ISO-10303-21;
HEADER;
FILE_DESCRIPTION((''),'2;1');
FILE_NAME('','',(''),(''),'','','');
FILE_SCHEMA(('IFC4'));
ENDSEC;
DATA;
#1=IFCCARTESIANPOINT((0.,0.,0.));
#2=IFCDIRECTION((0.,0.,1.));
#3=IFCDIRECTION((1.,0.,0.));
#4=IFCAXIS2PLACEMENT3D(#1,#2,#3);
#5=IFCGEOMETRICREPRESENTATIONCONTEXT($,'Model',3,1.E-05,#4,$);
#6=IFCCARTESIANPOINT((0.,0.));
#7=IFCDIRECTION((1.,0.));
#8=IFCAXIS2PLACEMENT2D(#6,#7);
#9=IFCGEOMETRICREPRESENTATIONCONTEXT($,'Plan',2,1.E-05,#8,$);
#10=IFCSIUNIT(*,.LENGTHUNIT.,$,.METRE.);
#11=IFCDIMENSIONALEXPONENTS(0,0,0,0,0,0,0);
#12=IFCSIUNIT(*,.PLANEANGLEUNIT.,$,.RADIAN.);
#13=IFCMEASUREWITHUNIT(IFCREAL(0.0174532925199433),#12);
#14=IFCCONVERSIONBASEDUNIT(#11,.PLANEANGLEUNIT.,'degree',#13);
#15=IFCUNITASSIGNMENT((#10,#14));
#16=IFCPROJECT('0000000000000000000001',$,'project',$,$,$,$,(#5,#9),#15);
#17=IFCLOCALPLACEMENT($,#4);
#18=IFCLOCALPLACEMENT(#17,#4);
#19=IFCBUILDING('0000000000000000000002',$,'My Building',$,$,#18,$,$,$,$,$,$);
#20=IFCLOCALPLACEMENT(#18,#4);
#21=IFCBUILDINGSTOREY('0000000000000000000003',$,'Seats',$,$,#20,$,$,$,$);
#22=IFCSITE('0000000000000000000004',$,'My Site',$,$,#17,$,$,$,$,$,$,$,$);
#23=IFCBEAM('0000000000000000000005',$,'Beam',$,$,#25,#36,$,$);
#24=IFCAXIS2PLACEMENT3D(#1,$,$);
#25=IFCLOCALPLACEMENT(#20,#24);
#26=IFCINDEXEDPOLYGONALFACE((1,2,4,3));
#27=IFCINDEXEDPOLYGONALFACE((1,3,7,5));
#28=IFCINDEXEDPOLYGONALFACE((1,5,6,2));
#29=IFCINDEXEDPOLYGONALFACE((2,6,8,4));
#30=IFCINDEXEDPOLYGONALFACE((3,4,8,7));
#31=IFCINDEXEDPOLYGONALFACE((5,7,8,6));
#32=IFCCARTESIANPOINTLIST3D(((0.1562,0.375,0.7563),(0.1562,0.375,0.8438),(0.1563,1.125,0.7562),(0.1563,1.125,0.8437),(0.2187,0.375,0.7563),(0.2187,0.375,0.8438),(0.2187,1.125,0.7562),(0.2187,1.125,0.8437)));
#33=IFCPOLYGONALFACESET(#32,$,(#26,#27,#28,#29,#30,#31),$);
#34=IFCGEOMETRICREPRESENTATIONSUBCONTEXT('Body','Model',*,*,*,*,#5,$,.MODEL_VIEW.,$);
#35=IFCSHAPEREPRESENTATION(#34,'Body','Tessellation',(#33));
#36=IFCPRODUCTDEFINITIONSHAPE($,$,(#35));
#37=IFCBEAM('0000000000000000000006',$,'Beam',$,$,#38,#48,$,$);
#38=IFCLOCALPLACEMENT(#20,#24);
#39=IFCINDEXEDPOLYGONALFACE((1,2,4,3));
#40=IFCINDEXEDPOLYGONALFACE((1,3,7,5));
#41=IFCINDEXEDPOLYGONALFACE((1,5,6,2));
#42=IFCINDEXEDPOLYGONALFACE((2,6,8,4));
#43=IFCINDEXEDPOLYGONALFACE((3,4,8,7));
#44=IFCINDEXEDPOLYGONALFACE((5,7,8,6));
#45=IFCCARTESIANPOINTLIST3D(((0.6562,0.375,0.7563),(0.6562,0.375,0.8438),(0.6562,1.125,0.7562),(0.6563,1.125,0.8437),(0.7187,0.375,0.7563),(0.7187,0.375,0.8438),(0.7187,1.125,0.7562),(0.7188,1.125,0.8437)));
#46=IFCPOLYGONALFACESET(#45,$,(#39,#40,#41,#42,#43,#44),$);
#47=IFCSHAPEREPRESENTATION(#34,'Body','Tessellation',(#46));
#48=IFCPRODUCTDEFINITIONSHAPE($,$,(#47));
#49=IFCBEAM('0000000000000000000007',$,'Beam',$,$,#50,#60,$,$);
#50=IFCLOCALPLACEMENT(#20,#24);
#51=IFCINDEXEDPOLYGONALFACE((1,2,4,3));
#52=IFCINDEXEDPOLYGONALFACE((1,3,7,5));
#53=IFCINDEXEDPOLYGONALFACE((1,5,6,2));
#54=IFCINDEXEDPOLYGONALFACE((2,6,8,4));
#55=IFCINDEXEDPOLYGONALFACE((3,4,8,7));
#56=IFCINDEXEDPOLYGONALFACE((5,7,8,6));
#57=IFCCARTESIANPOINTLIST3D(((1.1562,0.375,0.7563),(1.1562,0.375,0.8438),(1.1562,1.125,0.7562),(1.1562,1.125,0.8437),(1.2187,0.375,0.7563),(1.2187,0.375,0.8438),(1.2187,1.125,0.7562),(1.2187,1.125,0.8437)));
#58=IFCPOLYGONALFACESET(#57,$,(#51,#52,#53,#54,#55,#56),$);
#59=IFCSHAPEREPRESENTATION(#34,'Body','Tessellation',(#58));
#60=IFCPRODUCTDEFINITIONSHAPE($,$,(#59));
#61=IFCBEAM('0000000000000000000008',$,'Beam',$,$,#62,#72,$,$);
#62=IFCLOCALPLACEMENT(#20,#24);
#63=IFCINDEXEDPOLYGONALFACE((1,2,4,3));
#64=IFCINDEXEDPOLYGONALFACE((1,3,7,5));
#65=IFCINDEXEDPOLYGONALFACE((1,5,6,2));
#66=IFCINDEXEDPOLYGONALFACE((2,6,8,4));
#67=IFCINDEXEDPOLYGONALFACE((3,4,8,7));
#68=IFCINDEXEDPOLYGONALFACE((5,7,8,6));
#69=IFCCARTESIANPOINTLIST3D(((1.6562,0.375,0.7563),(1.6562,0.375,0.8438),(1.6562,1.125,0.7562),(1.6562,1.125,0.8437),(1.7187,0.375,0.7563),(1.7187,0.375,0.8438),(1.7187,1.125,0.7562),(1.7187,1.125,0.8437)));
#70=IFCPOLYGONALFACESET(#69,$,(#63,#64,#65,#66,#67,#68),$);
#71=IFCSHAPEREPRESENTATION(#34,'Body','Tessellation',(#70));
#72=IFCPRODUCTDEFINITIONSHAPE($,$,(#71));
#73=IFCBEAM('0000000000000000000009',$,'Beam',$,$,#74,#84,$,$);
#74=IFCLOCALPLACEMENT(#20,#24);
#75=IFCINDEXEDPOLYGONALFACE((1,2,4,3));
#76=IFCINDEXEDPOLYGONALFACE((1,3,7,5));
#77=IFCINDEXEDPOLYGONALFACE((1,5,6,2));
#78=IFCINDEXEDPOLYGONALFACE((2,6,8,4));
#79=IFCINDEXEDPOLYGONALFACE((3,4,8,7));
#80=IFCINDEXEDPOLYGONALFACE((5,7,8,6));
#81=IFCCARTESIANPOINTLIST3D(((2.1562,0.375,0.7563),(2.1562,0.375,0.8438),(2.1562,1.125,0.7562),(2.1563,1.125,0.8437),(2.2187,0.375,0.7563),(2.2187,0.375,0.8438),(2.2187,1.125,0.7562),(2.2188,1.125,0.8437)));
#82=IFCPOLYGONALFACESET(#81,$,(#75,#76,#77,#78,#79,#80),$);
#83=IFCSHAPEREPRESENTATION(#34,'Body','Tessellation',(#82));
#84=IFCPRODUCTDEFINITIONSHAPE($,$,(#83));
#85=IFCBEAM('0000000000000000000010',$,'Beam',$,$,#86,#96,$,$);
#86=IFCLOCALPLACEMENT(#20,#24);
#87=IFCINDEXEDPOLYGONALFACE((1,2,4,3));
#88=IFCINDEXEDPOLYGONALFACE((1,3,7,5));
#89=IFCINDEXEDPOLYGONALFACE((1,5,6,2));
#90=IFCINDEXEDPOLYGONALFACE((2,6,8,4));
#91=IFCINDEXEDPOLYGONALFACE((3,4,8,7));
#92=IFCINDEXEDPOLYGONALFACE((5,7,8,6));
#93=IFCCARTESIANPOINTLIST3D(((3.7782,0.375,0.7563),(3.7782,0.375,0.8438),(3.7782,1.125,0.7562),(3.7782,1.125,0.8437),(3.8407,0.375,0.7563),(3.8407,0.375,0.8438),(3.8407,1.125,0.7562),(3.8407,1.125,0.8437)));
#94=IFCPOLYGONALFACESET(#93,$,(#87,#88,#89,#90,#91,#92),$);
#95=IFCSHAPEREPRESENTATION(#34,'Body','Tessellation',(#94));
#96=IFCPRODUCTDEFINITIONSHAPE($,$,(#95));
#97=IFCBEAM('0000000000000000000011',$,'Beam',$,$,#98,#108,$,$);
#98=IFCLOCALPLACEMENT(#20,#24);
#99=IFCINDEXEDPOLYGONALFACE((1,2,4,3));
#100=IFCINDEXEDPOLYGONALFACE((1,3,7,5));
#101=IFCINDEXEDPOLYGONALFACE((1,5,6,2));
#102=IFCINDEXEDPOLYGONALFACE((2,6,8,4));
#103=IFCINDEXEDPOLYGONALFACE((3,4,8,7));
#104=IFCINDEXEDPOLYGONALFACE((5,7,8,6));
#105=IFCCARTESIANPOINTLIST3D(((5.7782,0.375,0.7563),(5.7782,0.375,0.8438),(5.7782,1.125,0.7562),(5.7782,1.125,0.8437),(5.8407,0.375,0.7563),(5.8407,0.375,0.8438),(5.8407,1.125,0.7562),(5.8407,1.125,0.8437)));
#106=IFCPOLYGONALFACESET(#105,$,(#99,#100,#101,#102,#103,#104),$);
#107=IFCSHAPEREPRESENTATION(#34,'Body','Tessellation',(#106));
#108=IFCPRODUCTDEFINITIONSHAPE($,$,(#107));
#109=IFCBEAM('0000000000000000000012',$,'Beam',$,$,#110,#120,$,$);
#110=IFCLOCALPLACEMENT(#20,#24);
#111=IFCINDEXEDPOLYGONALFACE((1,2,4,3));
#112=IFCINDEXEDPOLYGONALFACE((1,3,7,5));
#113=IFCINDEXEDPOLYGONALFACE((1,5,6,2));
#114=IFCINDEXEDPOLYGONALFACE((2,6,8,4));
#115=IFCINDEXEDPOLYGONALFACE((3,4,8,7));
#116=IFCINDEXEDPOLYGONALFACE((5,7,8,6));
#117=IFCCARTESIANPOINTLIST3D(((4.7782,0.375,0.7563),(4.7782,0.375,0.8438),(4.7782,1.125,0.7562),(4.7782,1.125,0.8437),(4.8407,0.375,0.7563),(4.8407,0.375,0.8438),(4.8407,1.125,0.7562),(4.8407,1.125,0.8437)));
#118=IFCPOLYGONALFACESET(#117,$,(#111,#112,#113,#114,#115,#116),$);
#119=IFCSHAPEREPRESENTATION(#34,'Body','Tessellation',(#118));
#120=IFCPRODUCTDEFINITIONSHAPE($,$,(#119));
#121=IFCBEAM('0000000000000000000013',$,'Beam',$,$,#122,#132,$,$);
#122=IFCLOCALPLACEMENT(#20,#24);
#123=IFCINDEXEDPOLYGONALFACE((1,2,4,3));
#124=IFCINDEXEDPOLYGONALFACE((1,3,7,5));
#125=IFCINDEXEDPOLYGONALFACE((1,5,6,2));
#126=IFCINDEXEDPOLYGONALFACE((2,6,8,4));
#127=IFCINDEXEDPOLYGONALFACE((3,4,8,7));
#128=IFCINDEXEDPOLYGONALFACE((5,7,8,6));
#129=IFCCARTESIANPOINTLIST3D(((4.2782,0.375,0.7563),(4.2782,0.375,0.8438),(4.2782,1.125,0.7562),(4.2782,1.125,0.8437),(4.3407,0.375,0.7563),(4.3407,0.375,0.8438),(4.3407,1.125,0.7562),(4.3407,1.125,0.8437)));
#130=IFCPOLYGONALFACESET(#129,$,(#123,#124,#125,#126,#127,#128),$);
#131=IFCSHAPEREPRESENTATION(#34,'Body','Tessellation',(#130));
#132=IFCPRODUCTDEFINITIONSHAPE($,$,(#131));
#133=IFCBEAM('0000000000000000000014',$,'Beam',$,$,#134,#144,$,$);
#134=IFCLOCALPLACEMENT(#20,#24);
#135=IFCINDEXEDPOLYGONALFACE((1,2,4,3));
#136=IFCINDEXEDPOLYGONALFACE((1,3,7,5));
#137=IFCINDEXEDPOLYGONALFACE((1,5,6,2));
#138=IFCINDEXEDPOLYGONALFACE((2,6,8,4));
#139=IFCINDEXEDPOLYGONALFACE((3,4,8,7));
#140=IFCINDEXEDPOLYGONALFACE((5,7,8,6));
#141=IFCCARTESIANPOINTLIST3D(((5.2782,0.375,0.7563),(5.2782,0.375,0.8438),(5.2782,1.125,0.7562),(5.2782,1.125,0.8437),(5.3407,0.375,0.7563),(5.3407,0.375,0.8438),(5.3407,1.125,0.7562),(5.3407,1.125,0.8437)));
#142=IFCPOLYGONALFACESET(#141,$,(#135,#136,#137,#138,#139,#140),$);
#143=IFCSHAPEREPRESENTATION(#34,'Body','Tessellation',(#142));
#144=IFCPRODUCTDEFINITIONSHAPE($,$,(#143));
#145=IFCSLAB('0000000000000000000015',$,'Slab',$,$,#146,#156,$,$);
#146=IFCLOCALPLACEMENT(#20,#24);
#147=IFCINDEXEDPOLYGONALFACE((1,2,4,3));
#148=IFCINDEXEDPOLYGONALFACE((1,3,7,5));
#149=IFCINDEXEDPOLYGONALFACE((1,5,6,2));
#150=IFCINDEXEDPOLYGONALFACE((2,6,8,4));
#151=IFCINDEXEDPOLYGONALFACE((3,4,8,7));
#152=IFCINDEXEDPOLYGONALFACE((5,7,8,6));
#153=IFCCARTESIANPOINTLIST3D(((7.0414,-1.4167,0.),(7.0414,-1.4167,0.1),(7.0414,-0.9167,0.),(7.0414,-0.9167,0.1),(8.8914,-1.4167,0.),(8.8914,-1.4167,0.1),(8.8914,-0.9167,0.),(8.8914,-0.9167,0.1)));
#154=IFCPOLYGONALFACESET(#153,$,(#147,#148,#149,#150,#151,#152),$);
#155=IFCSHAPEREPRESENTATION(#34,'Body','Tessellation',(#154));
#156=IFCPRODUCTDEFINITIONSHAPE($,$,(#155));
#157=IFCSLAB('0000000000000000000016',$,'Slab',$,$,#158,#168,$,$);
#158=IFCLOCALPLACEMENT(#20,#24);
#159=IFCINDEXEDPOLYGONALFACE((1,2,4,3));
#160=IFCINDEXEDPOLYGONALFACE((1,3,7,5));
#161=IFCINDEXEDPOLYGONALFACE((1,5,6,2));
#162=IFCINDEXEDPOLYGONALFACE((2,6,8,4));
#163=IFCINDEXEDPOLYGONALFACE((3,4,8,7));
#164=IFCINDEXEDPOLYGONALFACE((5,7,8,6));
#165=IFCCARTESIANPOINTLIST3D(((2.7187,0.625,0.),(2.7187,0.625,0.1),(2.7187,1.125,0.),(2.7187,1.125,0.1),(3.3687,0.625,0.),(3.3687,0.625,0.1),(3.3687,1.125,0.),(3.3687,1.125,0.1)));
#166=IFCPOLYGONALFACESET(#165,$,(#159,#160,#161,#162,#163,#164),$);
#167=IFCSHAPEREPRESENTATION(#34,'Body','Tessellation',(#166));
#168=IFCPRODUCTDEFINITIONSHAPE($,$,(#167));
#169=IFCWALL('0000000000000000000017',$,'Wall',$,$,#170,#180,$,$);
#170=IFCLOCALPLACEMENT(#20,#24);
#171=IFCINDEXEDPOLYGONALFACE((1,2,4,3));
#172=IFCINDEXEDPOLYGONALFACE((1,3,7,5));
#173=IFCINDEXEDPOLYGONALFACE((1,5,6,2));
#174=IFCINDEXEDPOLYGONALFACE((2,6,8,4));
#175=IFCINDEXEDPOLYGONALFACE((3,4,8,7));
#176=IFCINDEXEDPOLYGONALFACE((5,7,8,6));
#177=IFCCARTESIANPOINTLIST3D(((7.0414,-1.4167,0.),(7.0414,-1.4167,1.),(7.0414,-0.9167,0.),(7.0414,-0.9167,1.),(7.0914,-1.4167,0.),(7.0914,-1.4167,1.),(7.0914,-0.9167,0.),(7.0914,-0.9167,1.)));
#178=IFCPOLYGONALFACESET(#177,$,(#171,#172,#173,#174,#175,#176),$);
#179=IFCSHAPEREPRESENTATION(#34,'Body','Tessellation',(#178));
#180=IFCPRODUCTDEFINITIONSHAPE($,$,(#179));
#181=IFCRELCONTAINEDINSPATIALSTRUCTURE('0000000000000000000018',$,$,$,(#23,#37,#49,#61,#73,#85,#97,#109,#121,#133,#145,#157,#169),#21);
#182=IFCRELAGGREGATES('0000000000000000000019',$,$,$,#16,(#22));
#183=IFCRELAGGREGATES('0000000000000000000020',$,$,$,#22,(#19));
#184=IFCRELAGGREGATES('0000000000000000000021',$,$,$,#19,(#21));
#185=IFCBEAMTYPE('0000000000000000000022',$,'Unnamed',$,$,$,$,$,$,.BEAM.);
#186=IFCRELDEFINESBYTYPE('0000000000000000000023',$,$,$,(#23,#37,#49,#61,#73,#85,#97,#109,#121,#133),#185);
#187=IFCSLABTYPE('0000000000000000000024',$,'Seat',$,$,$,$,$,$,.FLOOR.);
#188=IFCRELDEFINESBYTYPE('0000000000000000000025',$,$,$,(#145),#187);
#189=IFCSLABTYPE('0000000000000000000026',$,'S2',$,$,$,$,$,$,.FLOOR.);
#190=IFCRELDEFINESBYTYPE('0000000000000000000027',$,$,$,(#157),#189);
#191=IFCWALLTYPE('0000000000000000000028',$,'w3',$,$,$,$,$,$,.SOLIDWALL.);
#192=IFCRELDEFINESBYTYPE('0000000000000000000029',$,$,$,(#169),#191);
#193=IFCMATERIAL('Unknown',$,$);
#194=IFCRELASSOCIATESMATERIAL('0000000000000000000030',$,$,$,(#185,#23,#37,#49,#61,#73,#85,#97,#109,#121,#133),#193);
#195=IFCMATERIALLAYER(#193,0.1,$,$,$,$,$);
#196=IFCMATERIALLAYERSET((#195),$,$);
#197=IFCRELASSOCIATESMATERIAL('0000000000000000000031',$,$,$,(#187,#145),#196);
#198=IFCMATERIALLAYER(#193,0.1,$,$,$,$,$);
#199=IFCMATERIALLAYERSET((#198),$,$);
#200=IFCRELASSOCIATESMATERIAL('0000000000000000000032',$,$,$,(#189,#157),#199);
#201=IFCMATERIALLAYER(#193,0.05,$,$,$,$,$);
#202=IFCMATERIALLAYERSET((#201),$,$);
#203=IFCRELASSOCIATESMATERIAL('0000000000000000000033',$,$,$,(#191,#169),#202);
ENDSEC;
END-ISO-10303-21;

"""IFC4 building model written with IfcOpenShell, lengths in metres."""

from ifc_helpers import new_model, entity, si_unit, converted_unit, frame, origin_with_axes, origin_2d_with_axis, place, context, subcontext, project, spatial, line, indexed_curve, outline, extrude, material, layer, layer_set, layer_usage, material_profile, profile_set, profile_usage, type_object, element, save


model = new_model("IFC4")

# Units and contexts
model_context = context("Model", 3, precision=1e-05, world=origin_with_axes())
plan_context = context("Plan", 2, precision=1e-05, world=origin_2d_with_axis())
body_context = subcontext(model_context, "Body", "Model", "MODEL_VIEW")
ifc_project = project(units=[si_unit("LENGTHUNIT", "METRE"), converted_unit("PLANEANGLEUNIT", "degree", entity("IfcReal", 0.0174532925199433), si_unit("PLANEANGLEUNIT", "RADIAN"), dimensions=[0, 0, 0, 0, 0, 0, 0])], contexts=[model_context, plan_context])

# Site, building, storey
site_placement = place(None, origin_with_axes())
site = spatial("IfcSite", under=ifc_project, at=site_placement, Name="My Site")
building_placement = place(site_placement, origin_with_axes())
building = spatial("IfcBuilding", under=site, at=building_placement, Name="My Building")
storey_placement = place(building_placement, origin_with_axes())
storey = spatial("IfcBuildingStorey", under=building, at=storey_placement, Name="Seats")

# Beams
ifc_material = material(Name="Unknown")
ifc_material_profile = material_profile(ifc_material, outline(indexed_curve([(-0.0312, 0.0437), (0.0312, 0.0437), (0.0312, -0.0437), (-0.0312, -0.0437), (-0.0312, 0.0437)])))
ifc_profile_set = profile_set([ifc_material_profile])
ifc_profile_usage_1 = profile_usage(ifc_profile_set, cardinal=5)
beam_type = type_object("IfcBeamType", Name="Unnamed", PredefinedType="BEAM", material=ifc_profile_set)
beam_1_placement = place(storey_placement, frame((0.1875, 1.125, 0.8), z_axis=(0.0, -1.0, 0.0), x_axis=(1.0, 0.0, 0.0)))
element("IfcBeam", 1, at=beam_1_placement, inside=storey, type_object=beam_type, material=ifc_profile_usage_1, Name="Beam", context=body_context, shape_type="SweptSolid", body=[
    extrude(outline(indexed_curve([(-0.0312, 0.0437), (0.0312, 0.0437), (0.0312, -0.0437), (-0.0312, -0.0437), (-0.0312, 0.0437)])), origin_with_axes(), (0.0, 0.0, 1.0), 0.75),
])
ifc_profile_usage_2 = profile_usage(ifc_profile_set, cardinal=5)
beam_2_placement = place(storey_placement, frame((0.6875, 1.125, 0.8), z_axis=(0.0, -1.0, 0.0), x_axis=(1.0, 0.0, 0.0)))
element("IfcBeam", 2, at=beam_2_placement, inside=storey, type_object=beam_type, material=ifc_profile_usage_2, Name="Beam", context=body_context, shape_type="SweptSolid", body=[
    extrude(outline(indexed_curve([(-0.0312, 0.0437), (0.0312, 0.0437), (0.0312, -0.0437), (-0.0312, -0.0437), (-0.0312, 0.0437)])), origin_with_axes(), (0.0, 0.0, 1.0), 0.75),
])
ifc_profile_usage_3 = profile_usage(ifc_profile_set, cardinal=5)
beam_3_placement = place(storey_placement, frame((1.1875, 1.125, 0.8), z_axis=(0.0, -1.0, 0.0), x_axis=(1.0, 0.0, 0.0)))
element("IfcBeam", 3, at=beam_3_placement, inside=storey, type_object=beam_type, material=ifc_profile_usage_3, Name="Beam", context=body_context, shape_type="SweptSolid", body=[
    extrude(outline(indexed_curve([(-0.0312, 0.0437), (0.0312, 0.0437), (0.0312, -0.0437), (-0.0312, -0.0437), (-0.0312, 0.0437)])), origin_with_axes(), (0.0, 0.0, 1.0), 0.75),
])
ifc_profile_usage_4 = profile_usage(ifc_profile_set, cardinal=5)
beam_4_placement = place(storey_placement, frame((1.6875, 1.125, 0.8), z_axis=(0.0, -1.0, 0.0), x_axis=(1.0, 0.0, 0.0)))
element("IfcBeam", 4, at=beam_4_placement, inside=storey, type_object=beam_type, material=ifc_profile_usage_4, Name="Beam", context=body_context, shape_type="SweptSolid", body=[
    extrude(outline(indexed_curve([(-0.0312, 0.0437), (0.0312, 0.0437), (0.0312, -0.0437), (-0.0312, -0.0437), (-0.0312, 0.0437)])), origin_with_axes(), (0.0, 0.0, 1.0), 0.75),
])
ifc_profile_usage_5 = profile_usage(ifc_profile_set, cardinal=5)
beam_5_placement = place(storey_placement, frame((2.1875, 1.125, 0.8), z_axis=(0.0, -1.0, 0.0), x_axis=(1.0, 0.0, 0.0)))
element("IfcBeam", 5, at=beam_5_placement, inside=storey, type_object=beam_type, material=ifc_profile_usage_5, Name="Beam", context=body_context, shape_type="SweptSolid", body=[
    extrude(outline(indexed_curve([(-0.0312, 0.0437), (0.0312, 0.0437), (0.0312, -0.0437), (-0.0312, -0.0437), (-0.0312, 0.0437)])), origin_with_axes(), (0.0, 0.0, 1.0), 0.75),
])
ifc_profile_usage_6 = profile_usage(ifc_profile_set, cardinal=5)
beam_6_placement = place(storey_placement, frame((3.8094, 1.125, 0.8), z_axis=(0.0, -1.0, 0.0), x_axis=(1.0, 0.0, 0.0)))
element("IfcBeam", 6, at=beam_6_placement, inside=storey, type_object=beam_type, material=ifc_profile_usage_6, Name="Beam", context=body_context, shape_type="SweptSolid", body=[
    extrude(outline(indexed_curve([(-0.0312, 0.0437), (0.0312, 0.0437), (0.0312, -0.0437), (-0.0312, -0.0437), (-0.0312, 0.0437)])), origin_with_axes(), (0.0, 0.0, 1.0), 0.75),
])
ifc_profile_usage_7 = profile_usage(ifc_profile_set, cardinal=5)
beam_7_placement = place(storey_placement, frame((5.8094, 1.125, 0.8), z_axis=(0.0, -1.0, 0.0), x_axis=(1.0, 0.0, 0.0)))
element("IfcBeam", 7, at=beam_7_placement, inside=storey, type_object=beam_type, material=ifc_profile_usage_7, Name="Beam", context=body_context, shape_type="SweptSolid", body=[
    extrude(outline(indexed_curve([(-0.0312, 0.0437), (0.0312, 0.0437), (0.0312, -0.0437), (-0.0312, -0.0437), (-0.0312, 0.0437)])), origin_with_axes(), (0.0, 0.0, 1.0), 0.75),
])
ifc_profile_usage_8 = profile_usage(ifc_profile_set, cardinal=5)
beam_8_placement = place(storey_placement, frame((4.8094, 1.125, 0.8), z_axis=(0.0, -1.0, 0.0), x_axis=(1.0, 0.0, 0.0)))
element("IfcBeam", 8, at=beam_8_placement, inside=storey, type_object=beam_type, material=ifc_profile_usage_8, Name="Beam", context=body_context, shape_type="SweptSolid", body=[
    extrude(outline(indexed_curve([(-0.0312, 0.0437), (0.0312, 0.0437), (0.0312, -0.0437), (-0.0312, -0.0437), (-0.0312, 0.0437)])), origin_with_axes(), (0.0, 0.0, 1.0), 0.75),
])
ifc_profile_usage_9 = profile_usage(ifc_profile_set, cardinal=5)
beam_9_placement = place(storey_placement, frame((4.3094, 1.125, 0.8), z_axis=(0.0, -1.0, 0.0), x_axis=(1.0, 0.0, 0.0)))
element("IfcBeam", 9, at=beam_9_placement, inside=storey, type_object=beam_type, material=ifc_profile_usage_9, Name="Beam", context=body_context, shape_type="SweptSolid", body=[
    extrude(outline(indexed_curve([(-0.0312, 0.0437), (0.0312, 0.0437), (0.0312, -0.0437), (-0.0312, -0.0437), (-0.0312, 0.0437)])), origin_with_axes(), (0.0, 0.0, 1.0), 0.75),
])
ifc_profile_usage_10 = profile_usage(ifc_profile_set, cardinal=5)
beam_10_placement = place(storey_placement, frame((5.3094, 1.125, 0.8), z_axis=(0.0, -1.0, 0.0), x_axis=(1.0, 0.0, 0.0)))
element("IfcBeam", 10, at=beam_10_placement, inside=storey, type_object=beam_type, material=ifc_profile_usage_10, Name="Beam", context=body_context, shape_type="SweptSolid", body=[
    extrude(outline(indexed_curve([(-0.0312, 0.0437), (0.0312, 0.0437), (0.0312, -0.0437), (-0.0312, -0.0437), (-0.0312, 0.0437)])), origin_with_axes(), (0.0, 0.0, 1.0), 0.75),
])

# Slabs
ifc_layer_1 = layer(ifc_material, 0.1)
ifc_layer_set_1 = layer_set([ifc_layer_1])
ifc_layer_usage_1 = layer_usage(ifc_layer_set_1, "AXIS3", "POSITIVE", -0.1)
slab_type_1 = type_object("IfcSlabType", Name="Seat", PredefinedType="FLOOR", material=ifc_layer_set_1)
slab_1_placement = place(storey_placement, frame((7.0414, -0.9167, 0.1), z_axis=(0.0, 0.0, 1.0), x_axis=(1.0, 0.0, 0.0)))
element("IfcSlab", 11, at=slab_1_placement, inside=storey, type_object=slab_type_1, material=ifc_layer_usage_1, Name="Slab", context=body_context, shape_type="SweptSolid", body=[
    extrude(outline(indexed_curve([(0.0, 0.0), (1.85, 0.0), (1.85, -0.5), (0.0, -0.5), (0.0, 0.0)])), frame((0.0, 0.0, -0.1), z_axis=(0.0, 0.0, 1.0), x_axis=(1.0, 0.0, 0.0)), (0.0, 0.0, 1.0), 0.1),
])
ifc_layer_2 = layer(ifc_material, 0.1)
ifc_layer_set_2 = layer_set([ifc_layer_2])
ifc_layer_usage_2 = layer_usage(ifc_layer_set_2, "AXIS3", "POSITIVE", -0.1)
slab_type_2 = type_object("IfcSlabType", Name="S2", PredefinedType="FLOOR", material=ifc_layer_set_2)
slab_2_placement = place(storey_placement, frame((3.3687, 0.625, 0.1), z_axis=(0.0, 0.0, 1.0), x_axis=(1.0, 0.0, 0.0)))
element("IfcSlab", 12, at=slab_2_placement, inside=storey, type_object=slab_type_2, material=ifc_layer_usage_2, Name="Slab", context=body_context, shape_type="SweptSolid", body=[
    extrude(outline(indexed_curve([(0.0, 0.0), (-0.65, 0.0), (-0.65, 0.5), (-0.0001, 0.5), (0.0, 0.0)])), frame((0.0, 0.0, -0.1), z_axis=(0.0, 0.0, 1.0), x_axis=(1.0, 0.0, 0.0)), (0.0, 0.0, 1.0), 0.1),
])

# Wall
ifc_layer_3 = layer(ifc_material, 0.05)
ifc_layer_set_3 = layer_set([ifc_layer_3])
ifc_layer_usage_3 = layer_usage(ifc_layer_set_3, "AXIS2", "POSITIVE", 0.0)
wall_type = type_object("IfcWallType", Name="w3", PredefinedType="SOLIDWALL", material=ifc_layer_set_3)
wall_1_placement = place(storey_placement, frame((7.0414, -0.9167, 0.0), z_axis=(0.0, 0.0, 1.0), x_axis=(0.0, -1.0, 0.0)))
element("IfcWall", 13, at=wall_1_placement, inside=storey, type_object=wall_type, material=ifc_layer_usage_3, Name="Wall", context=body_context, shape_type="SweptSolid", body=[
    extrude(outline(indexed_curve([(0.0, 0.0), (0.0, 0.05), (0.5, 0.05), (0.5, 0.0)], segments=[line(1, 2, 3, 4, 1)])), origin_with_axes(), (0.0, 0.0, 1.0), 1.0),
])

save(model, "model.ifc")
